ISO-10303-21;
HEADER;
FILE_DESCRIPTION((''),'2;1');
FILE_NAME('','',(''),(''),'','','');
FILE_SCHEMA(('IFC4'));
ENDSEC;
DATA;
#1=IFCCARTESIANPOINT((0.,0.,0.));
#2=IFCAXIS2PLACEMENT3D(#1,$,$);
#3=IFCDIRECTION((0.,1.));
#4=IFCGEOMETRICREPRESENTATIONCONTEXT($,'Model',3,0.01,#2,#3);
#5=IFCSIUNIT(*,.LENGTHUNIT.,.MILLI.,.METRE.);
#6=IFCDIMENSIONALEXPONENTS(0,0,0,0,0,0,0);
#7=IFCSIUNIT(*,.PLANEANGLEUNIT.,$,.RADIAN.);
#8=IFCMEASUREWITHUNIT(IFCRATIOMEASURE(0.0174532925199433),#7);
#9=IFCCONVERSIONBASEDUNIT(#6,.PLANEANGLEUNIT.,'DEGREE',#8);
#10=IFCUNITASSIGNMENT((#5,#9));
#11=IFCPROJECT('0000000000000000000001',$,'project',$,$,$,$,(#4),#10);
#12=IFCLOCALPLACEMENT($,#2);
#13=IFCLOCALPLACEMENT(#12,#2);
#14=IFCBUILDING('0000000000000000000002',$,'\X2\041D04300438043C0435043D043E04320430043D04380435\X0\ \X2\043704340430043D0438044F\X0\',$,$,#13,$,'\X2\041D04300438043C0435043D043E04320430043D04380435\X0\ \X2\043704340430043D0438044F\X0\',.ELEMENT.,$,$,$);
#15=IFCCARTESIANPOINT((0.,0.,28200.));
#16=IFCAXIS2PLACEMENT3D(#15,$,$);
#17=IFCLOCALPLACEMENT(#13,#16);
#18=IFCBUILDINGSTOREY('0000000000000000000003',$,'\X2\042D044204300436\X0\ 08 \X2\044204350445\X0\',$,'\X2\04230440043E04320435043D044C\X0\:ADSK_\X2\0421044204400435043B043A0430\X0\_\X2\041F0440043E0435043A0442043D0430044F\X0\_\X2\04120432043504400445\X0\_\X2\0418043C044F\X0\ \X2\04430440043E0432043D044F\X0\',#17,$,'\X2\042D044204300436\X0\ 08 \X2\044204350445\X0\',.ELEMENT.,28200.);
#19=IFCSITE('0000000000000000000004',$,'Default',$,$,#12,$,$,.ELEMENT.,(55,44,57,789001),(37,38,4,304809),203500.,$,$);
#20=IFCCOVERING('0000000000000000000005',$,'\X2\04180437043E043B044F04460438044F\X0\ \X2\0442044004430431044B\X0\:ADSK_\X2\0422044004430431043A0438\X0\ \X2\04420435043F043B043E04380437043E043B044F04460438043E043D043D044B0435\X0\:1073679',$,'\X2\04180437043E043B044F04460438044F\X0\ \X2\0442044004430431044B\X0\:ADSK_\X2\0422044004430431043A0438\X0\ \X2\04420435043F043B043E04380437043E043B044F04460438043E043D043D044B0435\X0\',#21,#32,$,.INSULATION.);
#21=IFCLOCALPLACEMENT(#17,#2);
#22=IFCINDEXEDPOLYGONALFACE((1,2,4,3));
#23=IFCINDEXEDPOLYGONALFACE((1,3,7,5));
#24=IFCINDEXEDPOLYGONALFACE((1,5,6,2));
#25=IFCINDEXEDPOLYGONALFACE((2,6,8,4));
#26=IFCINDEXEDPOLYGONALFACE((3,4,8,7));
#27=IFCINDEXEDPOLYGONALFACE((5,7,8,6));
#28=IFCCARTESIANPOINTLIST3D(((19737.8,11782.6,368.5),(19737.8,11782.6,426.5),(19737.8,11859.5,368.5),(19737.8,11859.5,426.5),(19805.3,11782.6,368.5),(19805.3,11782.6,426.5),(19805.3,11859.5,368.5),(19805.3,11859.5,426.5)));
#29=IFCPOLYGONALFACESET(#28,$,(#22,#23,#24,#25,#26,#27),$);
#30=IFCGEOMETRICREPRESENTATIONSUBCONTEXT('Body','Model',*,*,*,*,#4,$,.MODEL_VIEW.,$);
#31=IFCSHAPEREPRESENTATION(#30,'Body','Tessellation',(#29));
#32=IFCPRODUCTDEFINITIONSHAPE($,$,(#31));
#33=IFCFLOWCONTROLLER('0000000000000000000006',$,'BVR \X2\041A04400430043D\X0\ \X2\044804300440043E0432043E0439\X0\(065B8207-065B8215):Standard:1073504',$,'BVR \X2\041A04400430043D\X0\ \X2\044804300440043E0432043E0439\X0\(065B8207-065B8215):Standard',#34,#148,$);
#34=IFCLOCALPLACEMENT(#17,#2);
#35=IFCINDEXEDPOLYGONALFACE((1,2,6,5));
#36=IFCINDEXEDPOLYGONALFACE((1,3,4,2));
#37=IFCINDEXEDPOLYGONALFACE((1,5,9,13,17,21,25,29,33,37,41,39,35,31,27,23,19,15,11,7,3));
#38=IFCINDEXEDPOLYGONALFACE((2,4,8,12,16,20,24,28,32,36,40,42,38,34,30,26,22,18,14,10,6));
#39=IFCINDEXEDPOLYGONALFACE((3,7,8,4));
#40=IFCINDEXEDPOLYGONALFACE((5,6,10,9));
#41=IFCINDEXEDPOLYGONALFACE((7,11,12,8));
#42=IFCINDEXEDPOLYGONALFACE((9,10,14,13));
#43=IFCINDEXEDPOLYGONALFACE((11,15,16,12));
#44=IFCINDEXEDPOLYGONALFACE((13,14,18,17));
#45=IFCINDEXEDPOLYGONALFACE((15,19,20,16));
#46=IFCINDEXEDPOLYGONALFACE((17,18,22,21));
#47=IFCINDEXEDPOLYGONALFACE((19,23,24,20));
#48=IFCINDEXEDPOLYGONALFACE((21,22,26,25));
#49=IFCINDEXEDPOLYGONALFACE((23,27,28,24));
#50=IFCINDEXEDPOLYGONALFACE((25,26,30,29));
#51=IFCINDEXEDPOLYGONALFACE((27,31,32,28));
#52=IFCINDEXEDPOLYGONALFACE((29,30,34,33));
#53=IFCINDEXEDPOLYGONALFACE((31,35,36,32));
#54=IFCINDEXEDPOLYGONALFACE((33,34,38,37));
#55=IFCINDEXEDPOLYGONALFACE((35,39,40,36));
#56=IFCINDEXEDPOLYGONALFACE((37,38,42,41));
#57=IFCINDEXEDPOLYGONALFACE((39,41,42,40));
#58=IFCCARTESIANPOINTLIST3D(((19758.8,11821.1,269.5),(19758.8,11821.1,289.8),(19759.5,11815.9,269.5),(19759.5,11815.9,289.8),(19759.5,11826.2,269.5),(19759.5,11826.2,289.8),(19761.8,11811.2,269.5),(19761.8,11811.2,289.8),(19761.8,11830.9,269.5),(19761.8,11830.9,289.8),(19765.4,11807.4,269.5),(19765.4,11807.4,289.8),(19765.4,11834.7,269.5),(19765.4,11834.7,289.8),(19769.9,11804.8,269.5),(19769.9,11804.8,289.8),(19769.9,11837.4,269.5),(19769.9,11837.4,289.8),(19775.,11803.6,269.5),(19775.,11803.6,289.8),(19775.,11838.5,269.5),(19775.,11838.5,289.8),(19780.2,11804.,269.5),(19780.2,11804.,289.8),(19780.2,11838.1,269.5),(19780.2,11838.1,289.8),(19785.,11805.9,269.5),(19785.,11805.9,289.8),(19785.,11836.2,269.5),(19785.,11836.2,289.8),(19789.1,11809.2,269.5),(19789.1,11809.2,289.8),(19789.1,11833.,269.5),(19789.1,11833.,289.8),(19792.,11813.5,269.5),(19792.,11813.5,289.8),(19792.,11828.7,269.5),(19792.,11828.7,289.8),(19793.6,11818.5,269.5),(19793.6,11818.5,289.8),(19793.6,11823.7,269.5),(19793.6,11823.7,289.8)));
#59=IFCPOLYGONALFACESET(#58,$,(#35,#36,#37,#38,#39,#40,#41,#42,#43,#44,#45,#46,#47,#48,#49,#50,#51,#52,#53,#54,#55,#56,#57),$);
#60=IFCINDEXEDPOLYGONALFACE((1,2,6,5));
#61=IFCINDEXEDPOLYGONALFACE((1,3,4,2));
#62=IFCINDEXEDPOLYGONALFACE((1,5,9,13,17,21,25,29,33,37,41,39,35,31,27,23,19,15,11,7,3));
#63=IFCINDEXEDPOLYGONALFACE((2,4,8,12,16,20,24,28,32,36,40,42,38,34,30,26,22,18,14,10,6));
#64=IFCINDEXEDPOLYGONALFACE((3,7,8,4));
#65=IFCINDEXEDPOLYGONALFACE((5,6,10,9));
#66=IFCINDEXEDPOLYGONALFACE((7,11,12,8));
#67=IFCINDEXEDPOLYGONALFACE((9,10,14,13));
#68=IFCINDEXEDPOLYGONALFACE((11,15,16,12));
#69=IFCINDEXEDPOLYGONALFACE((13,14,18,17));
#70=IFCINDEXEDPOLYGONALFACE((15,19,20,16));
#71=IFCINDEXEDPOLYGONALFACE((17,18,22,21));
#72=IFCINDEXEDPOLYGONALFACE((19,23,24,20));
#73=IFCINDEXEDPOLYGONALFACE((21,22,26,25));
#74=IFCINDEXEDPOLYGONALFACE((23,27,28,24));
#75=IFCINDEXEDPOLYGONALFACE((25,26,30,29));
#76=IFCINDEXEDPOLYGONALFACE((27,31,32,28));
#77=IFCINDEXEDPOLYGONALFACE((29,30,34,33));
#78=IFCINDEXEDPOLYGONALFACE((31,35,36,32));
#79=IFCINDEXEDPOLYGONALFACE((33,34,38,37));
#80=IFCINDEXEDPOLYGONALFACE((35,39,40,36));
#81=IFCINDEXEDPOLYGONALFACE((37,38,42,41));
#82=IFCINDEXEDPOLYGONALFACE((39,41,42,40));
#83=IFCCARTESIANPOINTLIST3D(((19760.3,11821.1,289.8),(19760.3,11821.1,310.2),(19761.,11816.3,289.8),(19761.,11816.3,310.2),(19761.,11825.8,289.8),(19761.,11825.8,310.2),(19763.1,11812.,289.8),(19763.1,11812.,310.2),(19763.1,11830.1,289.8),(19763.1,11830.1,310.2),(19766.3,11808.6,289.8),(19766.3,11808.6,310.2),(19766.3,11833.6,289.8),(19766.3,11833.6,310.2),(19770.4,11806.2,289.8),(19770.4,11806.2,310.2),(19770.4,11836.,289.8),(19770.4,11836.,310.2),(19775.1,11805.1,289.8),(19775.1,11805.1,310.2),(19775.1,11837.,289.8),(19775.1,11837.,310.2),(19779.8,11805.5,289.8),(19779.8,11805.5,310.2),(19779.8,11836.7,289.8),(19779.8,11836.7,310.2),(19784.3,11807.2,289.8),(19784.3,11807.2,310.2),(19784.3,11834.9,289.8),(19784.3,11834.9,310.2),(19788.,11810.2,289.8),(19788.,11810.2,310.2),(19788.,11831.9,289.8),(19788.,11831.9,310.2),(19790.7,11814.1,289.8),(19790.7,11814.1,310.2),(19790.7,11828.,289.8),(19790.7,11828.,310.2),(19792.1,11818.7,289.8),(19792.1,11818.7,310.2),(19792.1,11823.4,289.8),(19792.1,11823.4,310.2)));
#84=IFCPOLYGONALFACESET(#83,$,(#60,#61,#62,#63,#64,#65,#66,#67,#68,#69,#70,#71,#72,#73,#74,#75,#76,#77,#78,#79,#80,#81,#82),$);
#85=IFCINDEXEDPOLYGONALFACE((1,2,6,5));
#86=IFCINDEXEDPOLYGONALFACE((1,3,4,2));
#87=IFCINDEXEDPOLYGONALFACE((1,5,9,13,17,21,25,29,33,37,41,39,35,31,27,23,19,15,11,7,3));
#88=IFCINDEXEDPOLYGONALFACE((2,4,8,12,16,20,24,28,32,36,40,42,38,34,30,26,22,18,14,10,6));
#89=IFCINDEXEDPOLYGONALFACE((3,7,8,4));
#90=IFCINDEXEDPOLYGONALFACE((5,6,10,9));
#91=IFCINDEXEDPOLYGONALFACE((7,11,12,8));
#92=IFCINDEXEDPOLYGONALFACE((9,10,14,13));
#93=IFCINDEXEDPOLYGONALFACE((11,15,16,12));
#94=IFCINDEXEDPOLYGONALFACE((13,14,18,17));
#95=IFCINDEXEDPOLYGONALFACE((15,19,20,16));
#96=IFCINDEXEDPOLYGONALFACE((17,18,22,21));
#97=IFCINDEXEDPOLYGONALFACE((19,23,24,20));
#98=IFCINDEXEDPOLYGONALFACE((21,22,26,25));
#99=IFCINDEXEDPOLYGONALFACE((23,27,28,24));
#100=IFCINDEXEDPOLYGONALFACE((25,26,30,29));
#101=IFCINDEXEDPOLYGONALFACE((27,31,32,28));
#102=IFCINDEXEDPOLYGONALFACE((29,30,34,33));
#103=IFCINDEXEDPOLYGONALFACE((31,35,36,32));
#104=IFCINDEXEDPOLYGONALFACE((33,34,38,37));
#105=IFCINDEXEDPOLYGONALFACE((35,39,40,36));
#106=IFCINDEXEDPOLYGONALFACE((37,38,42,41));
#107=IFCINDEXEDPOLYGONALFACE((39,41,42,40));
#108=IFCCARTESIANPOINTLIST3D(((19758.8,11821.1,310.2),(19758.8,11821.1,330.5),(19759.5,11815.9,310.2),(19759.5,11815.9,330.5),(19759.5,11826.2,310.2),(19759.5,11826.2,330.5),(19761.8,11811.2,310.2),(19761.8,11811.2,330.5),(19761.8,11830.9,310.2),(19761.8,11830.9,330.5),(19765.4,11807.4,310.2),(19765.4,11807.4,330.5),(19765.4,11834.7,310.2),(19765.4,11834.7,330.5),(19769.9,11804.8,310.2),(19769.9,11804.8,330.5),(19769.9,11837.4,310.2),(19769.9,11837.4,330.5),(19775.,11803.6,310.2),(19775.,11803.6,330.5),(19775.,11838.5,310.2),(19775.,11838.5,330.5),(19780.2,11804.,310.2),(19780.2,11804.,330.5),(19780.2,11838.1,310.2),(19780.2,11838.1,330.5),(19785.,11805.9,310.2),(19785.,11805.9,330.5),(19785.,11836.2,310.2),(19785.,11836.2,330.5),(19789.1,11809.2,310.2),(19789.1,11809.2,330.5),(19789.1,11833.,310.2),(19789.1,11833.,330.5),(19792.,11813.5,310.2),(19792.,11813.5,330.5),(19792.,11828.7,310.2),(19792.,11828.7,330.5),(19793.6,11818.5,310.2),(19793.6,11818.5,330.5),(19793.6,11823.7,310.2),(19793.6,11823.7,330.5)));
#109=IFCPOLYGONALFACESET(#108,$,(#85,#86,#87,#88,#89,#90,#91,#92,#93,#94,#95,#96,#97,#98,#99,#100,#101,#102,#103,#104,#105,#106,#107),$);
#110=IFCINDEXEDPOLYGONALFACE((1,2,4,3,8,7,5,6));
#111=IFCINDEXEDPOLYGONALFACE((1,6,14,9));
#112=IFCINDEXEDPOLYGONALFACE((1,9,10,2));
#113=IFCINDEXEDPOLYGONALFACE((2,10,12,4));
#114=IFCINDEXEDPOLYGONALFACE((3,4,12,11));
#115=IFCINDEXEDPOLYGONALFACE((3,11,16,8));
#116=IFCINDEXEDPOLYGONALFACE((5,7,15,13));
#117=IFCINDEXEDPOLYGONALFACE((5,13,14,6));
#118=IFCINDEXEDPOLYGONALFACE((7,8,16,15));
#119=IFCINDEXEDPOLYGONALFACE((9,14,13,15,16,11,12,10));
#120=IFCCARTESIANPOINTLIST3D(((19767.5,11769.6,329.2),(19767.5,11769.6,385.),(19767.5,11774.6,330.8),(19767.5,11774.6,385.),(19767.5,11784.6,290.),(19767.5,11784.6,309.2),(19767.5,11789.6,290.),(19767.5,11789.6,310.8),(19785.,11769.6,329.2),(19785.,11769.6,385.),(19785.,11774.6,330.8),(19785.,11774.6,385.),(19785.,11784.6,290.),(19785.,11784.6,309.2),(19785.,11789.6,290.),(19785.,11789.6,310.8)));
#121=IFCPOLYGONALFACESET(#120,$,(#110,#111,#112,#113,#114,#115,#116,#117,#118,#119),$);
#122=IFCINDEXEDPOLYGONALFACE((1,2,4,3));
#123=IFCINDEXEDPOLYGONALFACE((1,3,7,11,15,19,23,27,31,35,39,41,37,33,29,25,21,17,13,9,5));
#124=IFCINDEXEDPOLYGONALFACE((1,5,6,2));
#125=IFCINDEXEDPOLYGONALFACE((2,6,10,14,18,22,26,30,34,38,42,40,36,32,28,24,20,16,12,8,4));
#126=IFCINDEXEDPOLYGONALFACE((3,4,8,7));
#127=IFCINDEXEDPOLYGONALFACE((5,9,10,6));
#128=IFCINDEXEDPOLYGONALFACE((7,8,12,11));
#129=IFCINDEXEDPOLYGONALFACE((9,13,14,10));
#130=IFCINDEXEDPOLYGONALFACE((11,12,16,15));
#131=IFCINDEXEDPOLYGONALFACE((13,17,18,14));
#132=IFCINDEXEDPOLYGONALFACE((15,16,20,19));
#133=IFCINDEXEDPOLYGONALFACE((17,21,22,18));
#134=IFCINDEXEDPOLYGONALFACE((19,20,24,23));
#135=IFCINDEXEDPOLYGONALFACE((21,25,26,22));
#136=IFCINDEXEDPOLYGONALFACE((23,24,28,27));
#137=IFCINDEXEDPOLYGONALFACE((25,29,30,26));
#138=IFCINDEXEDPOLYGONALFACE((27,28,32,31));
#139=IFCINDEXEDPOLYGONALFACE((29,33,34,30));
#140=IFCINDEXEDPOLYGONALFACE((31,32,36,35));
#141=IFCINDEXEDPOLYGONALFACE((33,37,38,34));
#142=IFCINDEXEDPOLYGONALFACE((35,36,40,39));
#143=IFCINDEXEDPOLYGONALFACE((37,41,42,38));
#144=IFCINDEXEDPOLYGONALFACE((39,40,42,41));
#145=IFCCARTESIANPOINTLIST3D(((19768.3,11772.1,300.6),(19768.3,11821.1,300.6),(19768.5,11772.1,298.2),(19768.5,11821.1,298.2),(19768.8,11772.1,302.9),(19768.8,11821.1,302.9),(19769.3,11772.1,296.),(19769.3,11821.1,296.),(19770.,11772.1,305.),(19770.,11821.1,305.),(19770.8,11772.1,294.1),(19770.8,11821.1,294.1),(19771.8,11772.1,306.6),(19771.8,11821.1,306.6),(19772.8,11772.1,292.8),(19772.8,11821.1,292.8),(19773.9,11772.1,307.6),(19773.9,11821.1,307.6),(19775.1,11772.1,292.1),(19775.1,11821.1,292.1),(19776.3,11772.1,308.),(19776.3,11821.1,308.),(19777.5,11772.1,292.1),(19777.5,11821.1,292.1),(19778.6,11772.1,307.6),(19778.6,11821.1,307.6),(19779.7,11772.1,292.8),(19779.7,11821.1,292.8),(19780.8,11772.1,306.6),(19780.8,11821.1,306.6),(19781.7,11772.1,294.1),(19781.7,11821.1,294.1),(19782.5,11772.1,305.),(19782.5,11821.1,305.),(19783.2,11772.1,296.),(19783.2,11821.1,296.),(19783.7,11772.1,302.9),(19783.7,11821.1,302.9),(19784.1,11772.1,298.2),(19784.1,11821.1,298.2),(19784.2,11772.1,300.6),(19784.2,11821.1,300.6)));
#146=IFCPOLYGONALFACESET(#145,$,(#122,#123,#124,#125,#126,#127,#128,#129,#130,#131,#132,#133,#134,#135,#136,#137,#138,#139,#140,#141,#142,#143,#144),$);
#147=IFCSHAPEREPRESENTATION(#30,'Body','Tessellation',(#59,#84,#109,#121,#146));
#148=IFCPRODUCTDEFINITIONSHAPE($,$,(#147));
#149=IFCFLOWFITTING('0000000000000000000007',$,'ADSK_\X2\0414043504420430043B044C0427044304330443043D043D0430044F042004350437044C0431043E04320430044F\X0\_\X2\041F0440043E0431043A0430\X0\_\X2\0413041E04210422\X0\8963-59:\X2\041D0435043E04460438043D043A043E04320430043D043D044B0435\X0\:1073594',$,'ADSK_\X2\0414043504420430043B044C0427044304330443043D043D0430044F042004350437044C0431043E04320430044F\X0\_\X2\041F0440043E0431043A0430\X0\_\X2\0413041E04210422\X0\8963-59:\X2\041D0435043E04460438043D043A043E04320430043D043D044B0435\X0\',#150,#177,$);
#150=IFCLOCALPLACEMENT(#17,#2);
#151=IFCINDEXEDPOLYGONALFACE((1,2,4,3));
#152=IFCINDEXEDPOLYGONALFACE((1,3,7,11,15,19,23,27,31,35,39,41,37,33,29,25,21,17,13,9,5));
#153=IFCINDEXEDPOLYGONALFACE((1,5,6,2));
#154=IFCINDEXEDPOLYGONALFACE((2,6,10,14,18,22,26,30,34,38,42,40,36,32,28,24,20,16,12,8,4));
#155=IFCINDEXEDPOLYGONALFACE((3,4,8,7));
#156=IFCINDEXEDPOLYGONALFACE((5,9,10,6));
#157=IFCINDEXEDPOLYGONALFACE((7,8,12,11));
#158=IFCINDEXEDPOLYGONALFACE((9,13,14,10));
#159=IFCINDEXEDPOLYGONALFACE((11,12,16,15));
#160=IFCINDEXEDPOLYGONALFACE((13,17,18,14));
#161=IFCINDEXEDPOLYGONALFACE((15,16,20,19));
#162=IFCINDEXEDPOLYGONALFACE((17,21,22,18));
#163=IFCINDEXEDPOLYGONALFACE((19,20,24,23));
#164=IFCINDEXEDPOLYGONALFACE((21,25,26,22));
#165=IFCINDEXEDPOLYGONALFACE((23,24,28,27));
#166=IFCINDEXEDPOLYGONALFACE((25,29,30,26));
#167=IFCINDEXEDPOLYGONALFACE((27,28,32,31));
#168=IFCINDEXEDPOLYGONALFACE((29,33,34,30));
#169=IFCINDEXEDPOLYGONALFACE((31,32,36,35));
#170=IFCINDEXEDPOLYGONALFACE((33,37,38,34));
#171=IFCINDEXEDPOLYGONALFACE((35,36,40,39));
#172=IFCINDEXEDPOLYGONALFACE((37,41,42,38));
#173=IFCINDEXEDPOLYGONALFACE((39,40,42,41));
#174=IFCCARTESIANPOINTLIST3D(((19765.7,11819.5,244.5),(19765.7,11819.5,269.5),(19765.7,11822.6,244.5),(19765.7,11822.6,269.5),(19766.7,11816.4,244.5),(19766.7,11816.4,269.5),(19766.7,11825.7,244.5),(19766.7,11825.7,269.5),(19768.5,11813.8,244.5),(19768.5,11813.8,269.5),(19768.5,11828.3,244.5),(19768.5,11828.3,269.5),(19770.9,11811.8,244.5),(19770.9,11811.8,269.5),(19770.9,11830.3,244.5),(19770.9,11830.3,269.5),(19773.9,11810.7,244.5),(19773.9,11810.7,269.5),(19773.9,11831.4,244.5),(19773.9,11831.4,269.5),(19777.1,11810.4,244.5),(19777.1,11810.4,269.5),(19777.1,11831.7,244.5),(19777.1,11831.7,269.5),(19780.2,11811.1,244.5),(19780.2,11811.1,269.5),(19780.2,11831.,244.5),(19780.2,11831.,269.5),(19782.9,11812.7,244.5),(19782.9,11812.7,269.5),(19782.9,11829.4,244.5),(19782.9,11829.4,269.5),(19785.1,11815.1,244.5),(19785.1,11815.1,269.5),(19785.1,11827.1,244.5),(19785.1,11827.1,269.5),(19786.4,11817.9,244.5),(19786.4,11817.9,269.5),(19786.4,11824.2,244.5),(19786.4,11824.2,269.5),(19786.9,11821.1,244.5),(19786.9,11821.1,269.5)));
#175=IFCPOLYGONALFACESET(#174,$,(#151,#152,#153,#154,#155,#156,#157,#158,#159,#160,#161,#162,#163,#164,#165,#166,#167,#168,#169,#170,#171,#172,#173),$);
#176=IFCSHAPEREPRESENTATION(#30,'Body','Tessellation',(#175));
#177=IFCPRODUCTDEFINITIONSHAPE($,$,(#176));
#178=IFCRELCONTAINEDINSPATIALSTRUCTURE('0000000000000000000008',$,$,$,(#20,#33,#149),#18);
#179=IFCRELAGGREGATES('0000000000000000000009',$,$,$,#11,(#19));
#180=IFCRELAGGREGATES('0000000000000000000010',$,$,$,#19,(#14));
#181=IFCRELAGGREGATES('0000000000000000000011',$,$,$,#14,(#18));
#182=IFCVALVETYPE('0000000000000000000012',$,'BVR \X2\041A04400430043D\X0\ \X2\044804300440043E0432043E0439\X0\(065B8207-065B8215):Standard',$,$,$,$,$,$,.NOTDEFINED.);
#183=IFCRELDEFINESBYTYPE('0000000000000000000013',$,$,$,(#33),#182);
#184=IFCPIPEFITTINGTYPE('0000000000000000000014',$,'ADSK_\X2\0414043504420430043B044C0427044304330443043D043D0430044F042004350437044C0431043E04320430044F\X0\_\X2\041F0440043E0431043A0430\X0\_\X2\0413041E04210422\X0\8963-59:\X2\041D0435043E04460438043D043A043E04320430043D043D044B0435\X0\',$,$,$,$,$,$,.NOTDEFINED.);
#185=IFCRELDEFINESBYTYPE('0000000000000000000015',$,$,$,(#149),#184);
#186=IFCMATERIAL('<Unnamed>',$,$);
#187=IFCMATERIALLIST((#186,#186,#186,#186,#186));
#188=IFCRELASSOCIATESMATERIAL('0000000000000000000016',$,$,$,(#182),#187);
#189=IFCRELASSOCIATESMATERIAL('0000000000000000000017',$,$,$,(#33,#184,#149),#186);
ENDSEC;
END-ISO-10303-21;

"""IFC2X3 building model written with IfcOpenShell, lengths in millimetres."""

from ifc_helpers import new_model, entity, si_unit, converted_unit, direction, frame, origin, origin_2d_with_axis, place, context, subcontext, project, spatial, polyline, rectangle, circle, outline, extrude, source, transform, mapped, material, material_list, type_object, type_shapes, element, save


model = new_model("IFC2X3")

# Units and contexts
model_context = context("Model", 3, precision=0.01, world=origin(), true_north=direction((0.0, 1.0)))
body_context = subcontext(model_context, "Body", "Model", "MODEL_VIEW")
ifc_project = project(units=[si_unit("LENGTHUNIT", "METRE", prefix="MILLI"), converted_unit("PLANEANGLEUNIT", "DEGREE", entity("IfcRatioMeasure", 0.0174532925199433), si_unit("PLANEANGLEUNIT", "RADIAN"), dimensions=[0, 0, 0, 0, 0, 0, 0])], contexts=[model_context])

# Site, building, storey
site_placement = place(None, origin())
site = spatial("IfcSite", under=ifc_project, at=site_placement, Name="Default", CompositionType="ELEMENT", RefLatitude=(55, 44, 57, 789001), RefLongitude=(37, 38, 4, 304809), RefElevation=203500.0)
building_placement = place(site_placement, origin())
building = spatial("IfcBuilding", under=site, at=building_placement, Name="Наименование здания", LongName="Наименование здания", CompositionType="ELEMENT")
storey_placement = place(building_placement, frame((0.0, 0.0, 28200.0)))
storey = spatial("IfcBuildingStorey", under=building, at=storey_placement, Name="Этаж 08 тех", ObjectType="Уровень:ADSK_Стрелка_Проектная_Вверх_Имя уровня", LongName="Этаж 08 тех", CompositionType="ELEMENT", Elevation=28200.0)

# Covering
covering_1_placement = place(storey_placement, frame((19737.8, 11782.6, 368.5)))
element("IfcCovering", 1, at=covering_1_placement, inside=storey, Name="Изоляция трубы:ADSK_Трубки теплоизоляционные:1073679", ObjectType="Изоляция трубы:ADSK_Трубки теплоизоляционные", PredefinedType="INSULATION", context=body_context, shape_type="SweptSolid", body=[
    extrude(rectangle(XDim=67.4, YDim=76.9, at=origin_2d_with_axis()), frame((33.7, 38.5, 0.0)), (0.0, 0.0, 1.0), 58.0),
])

# Flow controller
ifc_material = material(Name="<Unnamed>")
ifc_material_list = material_list([ifc_material, ifc_material, ifc_material, ifc_material, ifc_material])
valve_type = type_object("IfcValveType", Name="BVR Кран шаровой(065B8207-065B8215):Standard", PredefinedType="NOTDEFINED", material=ifc_material_list)
shared_shape_1 = source(origin(), body_context, "Body", "SweptSolid", [
    extrude(circle(Radius=17.5, at=origin_2d_with_axis()), frame((-30.5, 0.0, 0.0), z_axis=(1.0, 0.0, 0.0), x_axis=(0.0, 1.0, 0.0)), (0.0, 0.0, 1.0), 20.3),
    extrude(circle(Radius=16.0, at=origin_2d_with_axis()), frame((-10.2, 0.0, 0.0), z_axis=(1.0, 0.0, 0.0), x_axis=(0.0, 1.0, 0.0)), (0.0, 0.0, 1.0), 20.3),
    extrude(circle(Radius=17.5, at=origin_2d_with_axis()), frame((10.2, 0.0, 0.0), z_axis=(1.0, 0.0, 0.0), x_axis=(0.0, 1.0, 0.0)), (0.0, 0.0, 1.0), 20.3),
    extrude(outline(polyline([(-38.8, -5.0), (-38.8, -10.0), (-17.9, -10.0), (2.1, 5.0), (56.2, 5.0), (56.2, 10.0), (0.4, 10.0), (-19.6, -5.0), (-38.8, -5.0)])), frame((28.8, -8.8, 41.5), z_axis=(0.0, -1.0, 0.0), x_axis=(1.0, 0.0, 0.0)), (0.0, 0.0, -1.0), 17.5),
    extrude(circle(Radius=8.0, at=origin_2d_with_axis()), origin(), (0.0, 0.0, 1.0), 49.0),
])
type_shapes(valve_type, [shared_shape_1])
flow_controller_placement = place(storey_placement, frame((19776.3, 11821.1, 300.0), z_axis=(0.0, -1.0, 0.0), x_axis=(0.0, 0.0, 1.0)))
element("IfcFlowController", 2, at=flow_controller_placement, inside=storey, type_object=valve_type, material=ifc_material, Name="BVR Кран шаровой(065B8207-065B8215):Standard:1073504", ObjectType="BVR Кран шаровой(065B8207-065B8215):Standard", context=body_context, shape_type="MappedRepresentation", body=[
    mapped(shared_shape_1, transform((0.0, 0.0, 0.0), scale=1.0)),
])

# Flow fitting
pipe_fitting_type_1 = type_object("IfcPipeFittingType", Name="ADSK_ДетальЧугуннаяРезьбовая_Пробка_ГОСТ8963-59:Неоцинкованные", PredefinedType="NOTDEFINED", material=ifc_material)
shared_shape_2 = source(origin(), body_context, "Body", "SweptSolid", [
    extrude(circle(Radius=10.7, at=origin_2d_with_axis()), frame((0.0, 0.0, 0.0), z_axis=(1.0, 0.0, 0.0), x_axis=(0.0, 1.0, 0.0)), (0.0, 0.0, 1.0), 25.0),
])
type_shapes(pipe_fitting_type_1, [shared_shape_2])
flow_fitting_placement = place(storey_placement, frame((19776.3, 11821.1, 269.5), z_axis=(0.0, -1.0, 0.0), x_axis=(0.0, 0.0, -1.0)))
element("IfcFlowFitting", 3, at=flow_fitting_placement, inside=storey, type_object=pipe_fitting_type_1, material=ifc_material, Name="ADSK_ДетальЧугуннаяРезьбовая_Пробка_ГОСТ8963-59:Неоцинкованные:1073594", ObjectType="ADSK_ДетальЧугуннаяРезьбовая_Пробка_ГОСТ8963-59:Неоцинкованные", context=body_context, shape_type="MappedRepresentation", body=[
    mapped(shared_shape_2, transform((0.0, 0.0, 0.0), scale=1.0)),
])

save(model, "model.ifc")
